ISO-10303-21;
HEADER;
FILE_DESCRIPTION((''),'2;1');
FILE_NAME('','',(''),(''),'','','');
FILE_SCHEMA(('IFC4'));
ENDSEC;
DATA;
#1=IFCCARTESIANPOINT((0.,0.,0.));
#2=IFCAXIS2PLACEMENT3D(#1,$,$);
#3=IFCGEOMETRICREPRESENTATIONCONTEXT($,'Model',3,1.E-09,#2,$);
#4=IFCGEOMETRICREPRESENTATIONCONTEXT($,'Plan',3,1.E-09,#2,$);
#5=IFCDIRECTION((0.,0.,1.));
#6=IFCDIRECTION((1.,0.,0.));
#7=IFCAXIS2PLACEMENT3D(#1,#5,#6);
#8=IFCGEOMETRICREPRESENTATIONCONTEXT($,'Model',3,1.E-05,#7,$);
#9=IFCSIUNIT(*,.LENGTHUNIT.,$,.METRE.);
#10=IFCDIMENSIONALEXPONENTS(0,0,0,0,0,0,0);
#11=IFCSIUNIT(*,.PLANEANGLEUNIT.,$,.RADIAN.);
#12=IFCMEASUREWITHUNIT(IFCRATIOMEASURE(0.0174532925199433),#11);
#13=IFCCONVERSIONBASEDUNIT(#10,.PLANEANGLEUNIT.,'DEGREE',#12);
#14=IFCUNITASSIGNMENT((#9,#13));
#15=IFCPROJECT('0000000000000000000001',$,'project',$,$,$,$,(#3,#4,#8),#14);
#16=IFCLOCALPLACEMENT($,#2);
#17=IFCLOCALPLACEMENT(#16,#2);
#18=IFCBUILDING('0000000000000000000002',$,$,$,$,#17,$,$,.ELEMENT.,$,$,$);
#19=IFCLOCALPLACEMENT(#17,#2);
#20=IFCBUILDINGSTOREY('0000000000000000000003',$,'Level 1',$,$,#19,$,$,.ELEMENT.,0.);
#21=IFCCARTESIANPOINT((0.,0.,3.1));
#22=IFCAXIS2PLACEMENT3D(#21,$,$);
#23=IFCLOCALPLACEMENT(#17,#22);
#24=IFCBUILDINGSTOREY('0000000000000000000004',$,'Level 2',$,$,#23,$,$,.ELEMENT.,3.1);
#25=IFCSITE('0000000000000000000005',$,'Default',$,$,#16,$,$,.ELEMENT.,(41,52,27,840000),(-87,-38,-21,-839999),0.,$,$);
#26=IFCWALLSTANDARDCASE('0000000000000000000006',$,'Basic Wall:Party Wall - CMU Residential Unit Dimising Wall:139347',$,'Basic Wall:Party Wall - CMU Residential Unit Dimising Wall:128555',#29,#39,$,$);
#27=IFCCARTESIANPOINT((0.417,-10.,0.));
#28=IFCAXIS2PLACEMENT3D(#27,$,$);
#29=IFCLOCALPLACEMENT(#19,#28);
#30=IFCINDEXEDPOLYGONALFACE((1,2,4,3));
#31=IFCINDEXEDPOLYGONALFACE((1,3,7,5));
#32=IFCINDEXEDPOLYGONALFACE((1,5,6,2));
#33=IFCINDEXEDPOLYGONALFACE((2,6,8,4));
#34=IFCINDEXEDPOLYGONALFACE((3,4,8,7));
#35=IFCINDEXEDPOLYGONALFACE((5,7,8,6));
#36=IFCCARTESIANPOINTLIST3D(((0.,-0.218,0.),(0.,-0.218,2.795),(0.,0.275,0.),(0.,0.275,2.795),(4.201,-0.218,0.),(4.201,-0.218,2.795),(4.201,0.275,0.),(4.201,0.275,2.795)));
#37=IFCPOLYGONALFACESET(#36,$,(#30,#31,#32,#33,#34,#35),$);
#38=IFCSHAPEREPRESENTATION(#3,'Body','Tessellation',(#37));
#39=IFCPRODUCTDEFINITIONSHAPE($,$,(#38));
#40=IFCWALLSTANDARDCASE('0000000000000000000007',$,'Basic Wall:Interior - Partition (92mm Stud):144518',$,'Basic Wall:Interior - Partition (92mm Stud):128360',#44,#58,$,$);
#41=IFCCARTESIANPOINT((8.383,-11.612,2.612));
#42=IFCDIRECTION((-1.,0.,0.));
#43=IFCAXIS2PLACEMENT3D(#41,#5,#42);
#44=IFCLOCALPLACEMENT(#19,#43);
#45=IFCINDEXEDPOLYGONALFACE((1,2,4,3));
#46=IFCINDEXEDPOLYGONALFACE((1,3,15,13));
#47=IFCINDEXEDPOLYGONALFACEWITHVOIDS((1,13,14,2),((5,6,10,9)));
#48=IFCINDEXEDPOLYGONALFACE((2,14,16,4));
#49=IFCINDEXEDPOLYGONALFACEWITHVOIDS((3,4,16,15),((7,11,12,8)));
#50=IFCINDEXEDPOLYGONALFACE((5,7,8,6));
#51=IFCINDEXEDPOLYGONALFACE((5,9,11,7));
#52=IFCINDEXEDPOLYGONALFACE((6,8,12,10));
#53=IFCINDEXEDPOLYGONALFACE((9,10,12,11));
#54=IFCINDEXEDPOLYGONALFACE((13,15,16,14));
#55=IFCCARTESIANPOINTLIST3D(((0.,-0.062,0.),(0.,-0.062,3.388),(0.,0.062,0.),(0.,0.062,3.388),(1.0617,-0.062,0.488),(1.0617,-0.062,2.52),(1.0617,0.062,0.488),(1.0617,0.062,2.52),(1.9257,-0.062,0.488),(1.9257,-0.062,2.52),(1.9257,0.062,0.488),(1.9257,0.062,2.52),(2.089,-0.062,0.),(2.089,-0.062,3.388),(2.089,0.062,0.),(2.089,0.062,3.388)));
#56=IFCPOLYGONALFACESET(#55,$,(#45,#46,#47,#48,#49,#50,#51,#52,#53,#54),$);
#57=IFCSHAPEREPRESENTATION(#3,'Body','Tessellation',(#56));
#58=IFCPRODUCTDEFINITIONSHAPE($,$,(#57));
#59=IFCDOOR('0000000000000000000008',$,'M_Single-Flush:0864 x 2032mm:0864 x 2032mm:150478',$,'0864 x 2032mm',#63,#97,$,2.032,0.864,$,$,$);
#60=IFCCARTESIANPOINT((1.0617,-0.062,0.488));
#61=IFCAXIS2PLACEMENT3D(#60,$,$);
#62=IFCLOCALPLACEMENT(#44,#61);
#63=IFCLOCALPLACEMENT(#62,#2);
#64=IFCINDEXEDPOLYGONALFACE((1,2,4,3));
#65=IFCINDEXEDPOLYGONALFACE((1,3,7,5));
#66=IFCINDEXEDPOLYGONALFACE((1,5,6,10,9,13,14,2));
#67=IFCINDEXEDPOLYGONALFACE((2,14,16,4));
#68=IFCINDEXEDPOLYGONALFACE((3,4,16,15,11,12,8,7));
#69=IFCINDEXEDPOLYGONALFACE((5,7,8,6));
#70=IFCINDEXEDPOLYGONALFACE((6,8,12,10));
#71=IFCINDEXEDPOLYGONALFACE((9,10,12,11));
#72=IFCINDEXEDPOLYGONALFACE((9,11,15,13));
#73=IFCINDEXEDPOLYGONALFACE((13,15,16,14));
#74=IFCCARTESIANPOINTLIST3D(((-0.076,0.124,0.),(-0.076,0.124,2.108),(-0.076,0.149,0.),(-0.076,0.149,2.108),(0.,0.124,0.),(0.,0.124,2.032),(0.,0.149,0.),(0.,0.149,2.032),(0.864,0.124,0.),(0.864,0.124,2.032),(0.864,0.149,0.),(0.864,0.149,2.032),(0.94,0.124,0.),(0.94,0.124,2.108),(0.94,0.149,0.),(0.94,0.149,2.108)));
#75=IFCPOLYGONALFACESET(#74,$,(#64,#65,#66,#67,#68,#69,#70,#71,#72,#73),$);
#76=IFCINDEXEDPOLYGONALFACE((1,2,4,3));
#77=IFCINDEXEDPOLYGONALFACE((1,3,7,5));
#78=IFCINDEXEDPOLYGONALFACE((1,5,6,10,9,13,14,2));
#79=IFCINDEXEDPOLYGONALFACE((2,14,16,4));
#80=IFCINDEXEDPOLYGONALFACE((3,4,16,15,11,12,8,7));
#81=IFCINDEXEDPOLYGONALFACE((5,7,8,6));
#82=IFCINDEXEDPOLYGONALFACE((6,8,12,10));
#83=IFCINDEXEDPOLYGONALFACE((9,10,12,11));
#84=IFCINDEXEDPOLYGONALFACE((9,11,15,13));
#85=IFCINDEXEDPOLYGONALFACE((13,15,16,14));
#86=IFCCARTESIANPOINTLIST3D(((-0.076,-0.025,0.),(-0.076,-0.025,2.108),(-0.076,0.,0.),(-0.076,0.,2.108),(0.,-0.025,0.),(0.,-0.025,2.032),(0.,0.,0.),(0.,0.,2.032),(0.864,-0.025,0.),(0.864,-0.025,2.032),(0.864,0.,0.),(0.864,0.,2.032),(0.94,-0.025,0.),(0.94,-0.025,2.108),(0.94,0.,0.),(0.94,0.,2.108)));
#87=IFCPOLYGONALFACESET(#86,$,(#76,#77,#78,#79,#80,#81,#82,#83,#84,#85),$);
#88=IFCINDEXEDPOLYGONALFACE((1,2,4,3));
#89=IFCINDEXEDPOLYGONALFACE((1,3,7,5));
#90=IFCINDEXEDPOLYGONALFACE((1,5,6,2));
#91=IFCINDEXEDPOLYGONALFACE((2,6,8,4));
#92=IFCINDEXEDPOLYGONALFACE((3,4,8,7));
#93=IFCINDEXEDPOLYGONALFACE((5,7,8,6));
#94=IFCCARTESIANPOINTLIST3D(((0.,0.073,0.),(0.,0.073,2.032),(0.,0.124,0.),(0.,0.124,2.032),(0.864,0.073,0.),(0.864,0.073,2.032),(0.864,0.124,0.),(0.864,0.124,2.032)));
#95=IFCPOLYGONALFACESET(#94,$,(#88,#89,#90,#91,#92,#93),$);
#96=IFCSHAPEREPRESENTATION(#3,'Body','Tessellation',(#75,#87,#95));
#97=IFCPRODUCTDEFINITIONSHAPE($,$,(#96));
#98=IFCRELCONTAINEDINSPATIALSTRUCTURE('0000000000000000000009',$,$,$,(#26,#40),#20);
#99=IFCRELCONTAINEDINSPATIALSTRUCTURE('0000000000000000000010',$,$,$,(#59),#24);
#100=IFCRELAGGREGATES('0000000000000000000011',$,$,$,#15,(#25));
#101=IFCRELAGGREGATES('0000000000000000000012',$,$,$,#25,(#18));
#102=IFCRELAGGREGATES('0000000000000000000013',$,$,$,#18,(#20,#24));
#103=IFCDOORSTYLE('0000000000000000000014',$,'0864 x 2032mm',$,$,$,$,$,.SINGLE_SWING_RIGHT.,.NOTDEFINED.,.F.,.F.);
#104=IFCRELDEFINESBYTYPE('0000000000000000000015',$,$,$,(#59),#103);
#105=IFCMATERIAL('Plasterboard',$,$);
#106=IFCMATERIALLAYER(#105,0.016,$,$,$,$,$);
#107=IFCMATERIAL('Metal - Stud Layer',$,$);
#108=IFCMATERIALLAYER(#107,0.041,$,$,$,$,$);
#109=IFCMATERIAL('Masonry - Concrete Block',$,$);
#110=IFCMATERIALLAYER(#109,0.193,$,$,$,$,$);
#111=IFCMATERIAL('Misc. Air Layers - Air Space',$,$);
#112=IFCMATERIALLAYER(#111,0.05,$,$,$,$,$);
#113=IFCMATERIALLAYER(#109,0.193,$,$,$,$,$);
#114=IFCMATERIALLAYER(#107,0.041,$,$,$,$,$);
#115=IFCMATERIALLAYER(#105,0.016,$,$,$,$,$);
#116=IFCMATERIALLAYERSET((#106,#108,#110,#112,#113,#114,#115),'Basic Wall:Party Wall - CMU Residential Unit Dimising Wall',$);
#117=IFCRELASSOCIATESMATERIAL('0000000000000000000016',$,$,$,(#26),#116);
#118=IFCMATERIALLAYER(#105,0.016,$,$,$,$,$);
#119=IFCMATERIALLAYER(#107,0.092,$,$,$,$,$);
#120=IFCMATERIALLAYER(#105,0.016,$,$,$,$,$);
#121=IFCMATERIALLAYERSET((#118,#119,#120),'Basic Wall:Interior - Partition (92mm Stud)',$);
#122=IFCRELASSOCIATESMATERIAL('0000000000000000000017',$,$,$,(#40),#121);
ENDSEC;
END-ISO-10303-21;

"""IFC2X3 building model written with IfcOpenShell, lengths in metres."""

from ifc_helpers import new_model, entity, si_unit, converted_unit, frame, frame_2d, origin, origin_with_axes, origin_2d_with_axis, place, context, project, spatial, polyline, rectangle, outline, extrude, clip, bounded_halfspace, source, transform, mapped, material, layer, layer_set, layer_usage, type_object, type_shapes, element, fill, save


model = new_model("IFC2X3")

# Units and contexts
model_context_1 = context("Model", 3, precision=1e-09, world=origin())
plan_context = context("Plan", 3, precision=1e-09, world=origin())
model_context_2 = context("Model", 3, precision=1e-05, world=origin_with_axes())
ifc_project = project(units=[si_unit("LENGTHUNIT", "METRE"), converted_unit("PLANEANGLEUNIT", "DEGREE", entity("IfcRatioMeasure", 0.0174532925199433), si_unit("PLANEANGLEUNIT", "RADIAN"), dimensions=[0, 0, 0, 0, 0, 0, 0])], contexts=[model_context_1, plan_context, model_context_2])

# Site, building, storey
site_placement = place(None, origin())
site = spatial("IfcSite", under=ifc_project, at=site_placement, Name="Default", CompositionType="ELEMENT", RefLatitude=(41, 52, 27, 840000), RefLongitude=(-87, -38, -21, -839999), RefElevation=0.0)
building_placement = place(site_placement, origin())
building = spatial("IfcBuilding", under=site, at=building_placement, CompositionType="ELEMENT")
storey_1_placement = place(building_placement, origin())
storey_1 = spatial("IfcBuildingStorey", under=building, at=storey_1_placement, Name="Level 1", CompositionType="ELEMENT", Elevation=0.0)

# Shared definitions
ifc_material_1 = material(Name="Misc. Air Layers - Air Space")
ifc_material_2 = material(Name="Masonry - Concrete Block")
ifc_material_3 = material(Name="Metal - Stud Layer")
ifc_material_4 = material(Name="Plasterboard")

# Wall
ifc_layer_1 = layer(ifc_material_4, 0.016)
ifc_layer_2 = layer(ifc_material_3, 0.041)
ifc_layer_3 = layer(ifc_material_2, 0.193)
ifc_layer_4 = layer(ifc_material_1, 0.05)
ifc_layer_5 = layer(ifc_material_2, 0.193)
ifc_layer_6 = layer(ifc_material_3, 0.041)
ifc_layer_7 = layer(ifc_material_4, 0.016)
ifc_layer_set_1 = layer_set([ifc_layer_1, ifc_layer_2, ifc_layer_3, ifc_layer_4, ifc_layer_5, ifc_layer_6, ifc_layer_7], Name="Basic Wall:Party Wall - CMU Residential Unit Dimising Wall")
ifc_layer_usage_1 = layer_usage(ifc_layer_set_1, "AXIS2", "NEGATIVE", 0.275)
wall_1_placement = place(storey_1_placement, frame((0.417, -10.0, 0.0)))
element("IfcWallStandardCase", 1, at=wall_1_placement, inside=storey_1, material=ifc_layer_usage_1, Name="Basic Wall:Party Wall - CMU Residential Unit Dimising Wall:139347", ObjectType="Basic Wall:Party Wall - CMU Residential Unit Dimising Wall:128555", context=model_context_1, shape_type="Clipping", body=[
    clip(clip(extrude(rectangle(XDim=4.201, YDim=0.55, at=frame_2d((2.1005, 0.0), x_axis=(-1.0, 0.0))), origin(), (0.0, 0.0, 1.0), 2.795), bounded_halfspace(frame((0.0, -0.218, 0.0), z_axis=(0.0, 1.0, 0.0), x_axis=(-1.0, 0.0, 0.0)), True, frame((0.0, -0.218, 0.0), z_axis=(0.0, 1.0, 0.0), x_axis=(-1.0, 0.0, 0.0)), polyline([(0.0, 0.0), (0.0, 2.795), (-4.201, 2.795), (-4.201, 0.0), (0.0, 0.0)]))), bounded_halfspace(frame((4.201, 0.275, 0.0), z_axis=(-1.0, 0.0, 0.0), x_axis=(0.0, -1.0, 0.0)), True, frame((4.201, 0.275, 0.0), z_axis=(-1.0, 0.0, 0.0), x_axis=(0.0, -1.0, 0.0)), polyline([(0.0, 0.0), (0.493, 0.0), (0.493, 2.795), (0.0, 2.795), (0.0, 0.0)]))),
])

# Shared definitions
ifc_layer_8 = layer(ifc_material_4, 0.016)
ifc_layer_9 = layer(ifc_material_3, 0.092)
ifc_layer_10 = layer(ifc_material_4, 0.016)
ifc_layer_set_2 = layer_set([ifc_layer_8, ifc_layer_9, ifc_layer_10], Name="Basic Wall:Interior - Partition (92mm Stud)")

# Wall, opening
ifc_layer_usage_2 = layer_usage(ifc_layer_set_2, "AXIS2", "NEGATIVE", 0.062)
wall_2_placement = place(storey_1_placement, frame((8.383, -11.612, 2.612), z_axis=(0.0, 0.0, 1.0), x_axis=(-1.0, 0.0, 0.0)))
wall_2 = element("IfcWallStandardCase", 2, at=wall_2_placement, inside=storey_1, material=ifc_layer_usage_2, Name="Basic Wall:Interior - Partition (92mm Stud):144518", ObjectType="Basic Wall:Interior - Partition (92mm Stud):128360", context=model_context_1, shape_type="SweptSolid", body=[
    extrude(rectangle(XDim=2.089, YDim=0.124, at=frame_2d((1.0445, 0.0), x_axis=(-1.0, 0.0))), origin(), (0.0, 0.0, 1.0), 3.388),
])
opening_1_placement = place(wall_2_placement, frame((1.0617, -0.062, 0.488)))
opening_1 = element("IfcOpeningElement", 3, at=opening_1_placement, cuts=wall_2, ObjectType="Opening", context=model_context_1, shape_type="SweptSolid", body=[
    extrude(rectangle(XDim=0.864, YDim=2.032, at=frame_2d((1.016, 0.432), x_axis=(0.0, 1.0))), frame((0.0, 0.0, 0.0), z_axis=(0.0, 1.0, 0.0), x_axis=(0.0, 0.0, 1.0)), (0.0, 0.0, 1.0), 0.124),
])

# Shared definitions
storey_2_placement = place(building_placement, frame((0.0, 0.0, 3.1)))
storey_2 = spatial("IfcBuildingStorey", under=building, at=storey_2_placement, Name="Level 2", CompositionType="ELEMENT", Elevation=3.1)

# Door
door_style_1 = type_object("IfcDoorStyle", Name="0864 x 2032mm", ConstructionType="NOTDEFINED", OperationType="SINGLE_SWING_RIGHT", ParameterTakesPrecedence=False, Sizeable=False)
shared_shape_1 = source(origin(), model_context_1, "Body", "SweptSolid", [
    extrude(outline(polyline([(-0.508, -1.073), (0.508, -1.073), (0.508, 1.035), (0.432, 1.035), (0.432, -0.997), (-0.432, -0.997), (-0.432, 1.035), (-0.508, 1.035), (-0.508, -1.073)])), frame((0.432, 0.124, 1.035), z_axis=(0.0, 1.0, 0.0), x_axis=(1.0, 0.0, 0.0)), (0.0, 0.0, 1.0), 0.025),
    extrude(outline(polyline([(-1.073, -0.508), (1.035, -0.508), (1.035, -0.432), (-0.997, -0.432), (-0.997, 0.432), (1.035, 0.432), (1.035, 0.508), (-1.073, 0.508), (-1.073, -0.508)])), frame((0.432, -0.025, 1.035), z_axis=(0.0, 1.0, 0.0), x_axis=(0.0, 0.0, -1.0)), (0.0, 0.0, 1.0), 0.025),
    extrude(rectangle(XDim=0.051, YDim=0.864, at=origin_2d_with_axis()), frame((0.432, 0.0985, 0.0), z_axis=(0.0, 0.0, 1.0), x_axis=(0.0, 1.0, 0.0)), (0.0, 0.0, 1.0), 2.032),
])
type_shapes(door_style_1, [shared_shape_1])
door_1_placement = place(opening_1_placement, origin())
door_1 = element("IfcDoor", 4, at=door_1_placement, inside=storey_2, type_object=door_style_1, Name="M_Single-Flush:0864 x 2032mm:0864 x 2032mm:150478", ObjectType="0864 x 2032mm", OverallHeight=2.032, OverallWidth=0.864, context=model_context_1, shape_type="MappedRepresentation", body=[
    mapped(shared_shape_1, transform((0.0, 0.0, 0.0), scale=1.0)),
])
fill(opening_1, door_1)

save(model, "model.ifc")
